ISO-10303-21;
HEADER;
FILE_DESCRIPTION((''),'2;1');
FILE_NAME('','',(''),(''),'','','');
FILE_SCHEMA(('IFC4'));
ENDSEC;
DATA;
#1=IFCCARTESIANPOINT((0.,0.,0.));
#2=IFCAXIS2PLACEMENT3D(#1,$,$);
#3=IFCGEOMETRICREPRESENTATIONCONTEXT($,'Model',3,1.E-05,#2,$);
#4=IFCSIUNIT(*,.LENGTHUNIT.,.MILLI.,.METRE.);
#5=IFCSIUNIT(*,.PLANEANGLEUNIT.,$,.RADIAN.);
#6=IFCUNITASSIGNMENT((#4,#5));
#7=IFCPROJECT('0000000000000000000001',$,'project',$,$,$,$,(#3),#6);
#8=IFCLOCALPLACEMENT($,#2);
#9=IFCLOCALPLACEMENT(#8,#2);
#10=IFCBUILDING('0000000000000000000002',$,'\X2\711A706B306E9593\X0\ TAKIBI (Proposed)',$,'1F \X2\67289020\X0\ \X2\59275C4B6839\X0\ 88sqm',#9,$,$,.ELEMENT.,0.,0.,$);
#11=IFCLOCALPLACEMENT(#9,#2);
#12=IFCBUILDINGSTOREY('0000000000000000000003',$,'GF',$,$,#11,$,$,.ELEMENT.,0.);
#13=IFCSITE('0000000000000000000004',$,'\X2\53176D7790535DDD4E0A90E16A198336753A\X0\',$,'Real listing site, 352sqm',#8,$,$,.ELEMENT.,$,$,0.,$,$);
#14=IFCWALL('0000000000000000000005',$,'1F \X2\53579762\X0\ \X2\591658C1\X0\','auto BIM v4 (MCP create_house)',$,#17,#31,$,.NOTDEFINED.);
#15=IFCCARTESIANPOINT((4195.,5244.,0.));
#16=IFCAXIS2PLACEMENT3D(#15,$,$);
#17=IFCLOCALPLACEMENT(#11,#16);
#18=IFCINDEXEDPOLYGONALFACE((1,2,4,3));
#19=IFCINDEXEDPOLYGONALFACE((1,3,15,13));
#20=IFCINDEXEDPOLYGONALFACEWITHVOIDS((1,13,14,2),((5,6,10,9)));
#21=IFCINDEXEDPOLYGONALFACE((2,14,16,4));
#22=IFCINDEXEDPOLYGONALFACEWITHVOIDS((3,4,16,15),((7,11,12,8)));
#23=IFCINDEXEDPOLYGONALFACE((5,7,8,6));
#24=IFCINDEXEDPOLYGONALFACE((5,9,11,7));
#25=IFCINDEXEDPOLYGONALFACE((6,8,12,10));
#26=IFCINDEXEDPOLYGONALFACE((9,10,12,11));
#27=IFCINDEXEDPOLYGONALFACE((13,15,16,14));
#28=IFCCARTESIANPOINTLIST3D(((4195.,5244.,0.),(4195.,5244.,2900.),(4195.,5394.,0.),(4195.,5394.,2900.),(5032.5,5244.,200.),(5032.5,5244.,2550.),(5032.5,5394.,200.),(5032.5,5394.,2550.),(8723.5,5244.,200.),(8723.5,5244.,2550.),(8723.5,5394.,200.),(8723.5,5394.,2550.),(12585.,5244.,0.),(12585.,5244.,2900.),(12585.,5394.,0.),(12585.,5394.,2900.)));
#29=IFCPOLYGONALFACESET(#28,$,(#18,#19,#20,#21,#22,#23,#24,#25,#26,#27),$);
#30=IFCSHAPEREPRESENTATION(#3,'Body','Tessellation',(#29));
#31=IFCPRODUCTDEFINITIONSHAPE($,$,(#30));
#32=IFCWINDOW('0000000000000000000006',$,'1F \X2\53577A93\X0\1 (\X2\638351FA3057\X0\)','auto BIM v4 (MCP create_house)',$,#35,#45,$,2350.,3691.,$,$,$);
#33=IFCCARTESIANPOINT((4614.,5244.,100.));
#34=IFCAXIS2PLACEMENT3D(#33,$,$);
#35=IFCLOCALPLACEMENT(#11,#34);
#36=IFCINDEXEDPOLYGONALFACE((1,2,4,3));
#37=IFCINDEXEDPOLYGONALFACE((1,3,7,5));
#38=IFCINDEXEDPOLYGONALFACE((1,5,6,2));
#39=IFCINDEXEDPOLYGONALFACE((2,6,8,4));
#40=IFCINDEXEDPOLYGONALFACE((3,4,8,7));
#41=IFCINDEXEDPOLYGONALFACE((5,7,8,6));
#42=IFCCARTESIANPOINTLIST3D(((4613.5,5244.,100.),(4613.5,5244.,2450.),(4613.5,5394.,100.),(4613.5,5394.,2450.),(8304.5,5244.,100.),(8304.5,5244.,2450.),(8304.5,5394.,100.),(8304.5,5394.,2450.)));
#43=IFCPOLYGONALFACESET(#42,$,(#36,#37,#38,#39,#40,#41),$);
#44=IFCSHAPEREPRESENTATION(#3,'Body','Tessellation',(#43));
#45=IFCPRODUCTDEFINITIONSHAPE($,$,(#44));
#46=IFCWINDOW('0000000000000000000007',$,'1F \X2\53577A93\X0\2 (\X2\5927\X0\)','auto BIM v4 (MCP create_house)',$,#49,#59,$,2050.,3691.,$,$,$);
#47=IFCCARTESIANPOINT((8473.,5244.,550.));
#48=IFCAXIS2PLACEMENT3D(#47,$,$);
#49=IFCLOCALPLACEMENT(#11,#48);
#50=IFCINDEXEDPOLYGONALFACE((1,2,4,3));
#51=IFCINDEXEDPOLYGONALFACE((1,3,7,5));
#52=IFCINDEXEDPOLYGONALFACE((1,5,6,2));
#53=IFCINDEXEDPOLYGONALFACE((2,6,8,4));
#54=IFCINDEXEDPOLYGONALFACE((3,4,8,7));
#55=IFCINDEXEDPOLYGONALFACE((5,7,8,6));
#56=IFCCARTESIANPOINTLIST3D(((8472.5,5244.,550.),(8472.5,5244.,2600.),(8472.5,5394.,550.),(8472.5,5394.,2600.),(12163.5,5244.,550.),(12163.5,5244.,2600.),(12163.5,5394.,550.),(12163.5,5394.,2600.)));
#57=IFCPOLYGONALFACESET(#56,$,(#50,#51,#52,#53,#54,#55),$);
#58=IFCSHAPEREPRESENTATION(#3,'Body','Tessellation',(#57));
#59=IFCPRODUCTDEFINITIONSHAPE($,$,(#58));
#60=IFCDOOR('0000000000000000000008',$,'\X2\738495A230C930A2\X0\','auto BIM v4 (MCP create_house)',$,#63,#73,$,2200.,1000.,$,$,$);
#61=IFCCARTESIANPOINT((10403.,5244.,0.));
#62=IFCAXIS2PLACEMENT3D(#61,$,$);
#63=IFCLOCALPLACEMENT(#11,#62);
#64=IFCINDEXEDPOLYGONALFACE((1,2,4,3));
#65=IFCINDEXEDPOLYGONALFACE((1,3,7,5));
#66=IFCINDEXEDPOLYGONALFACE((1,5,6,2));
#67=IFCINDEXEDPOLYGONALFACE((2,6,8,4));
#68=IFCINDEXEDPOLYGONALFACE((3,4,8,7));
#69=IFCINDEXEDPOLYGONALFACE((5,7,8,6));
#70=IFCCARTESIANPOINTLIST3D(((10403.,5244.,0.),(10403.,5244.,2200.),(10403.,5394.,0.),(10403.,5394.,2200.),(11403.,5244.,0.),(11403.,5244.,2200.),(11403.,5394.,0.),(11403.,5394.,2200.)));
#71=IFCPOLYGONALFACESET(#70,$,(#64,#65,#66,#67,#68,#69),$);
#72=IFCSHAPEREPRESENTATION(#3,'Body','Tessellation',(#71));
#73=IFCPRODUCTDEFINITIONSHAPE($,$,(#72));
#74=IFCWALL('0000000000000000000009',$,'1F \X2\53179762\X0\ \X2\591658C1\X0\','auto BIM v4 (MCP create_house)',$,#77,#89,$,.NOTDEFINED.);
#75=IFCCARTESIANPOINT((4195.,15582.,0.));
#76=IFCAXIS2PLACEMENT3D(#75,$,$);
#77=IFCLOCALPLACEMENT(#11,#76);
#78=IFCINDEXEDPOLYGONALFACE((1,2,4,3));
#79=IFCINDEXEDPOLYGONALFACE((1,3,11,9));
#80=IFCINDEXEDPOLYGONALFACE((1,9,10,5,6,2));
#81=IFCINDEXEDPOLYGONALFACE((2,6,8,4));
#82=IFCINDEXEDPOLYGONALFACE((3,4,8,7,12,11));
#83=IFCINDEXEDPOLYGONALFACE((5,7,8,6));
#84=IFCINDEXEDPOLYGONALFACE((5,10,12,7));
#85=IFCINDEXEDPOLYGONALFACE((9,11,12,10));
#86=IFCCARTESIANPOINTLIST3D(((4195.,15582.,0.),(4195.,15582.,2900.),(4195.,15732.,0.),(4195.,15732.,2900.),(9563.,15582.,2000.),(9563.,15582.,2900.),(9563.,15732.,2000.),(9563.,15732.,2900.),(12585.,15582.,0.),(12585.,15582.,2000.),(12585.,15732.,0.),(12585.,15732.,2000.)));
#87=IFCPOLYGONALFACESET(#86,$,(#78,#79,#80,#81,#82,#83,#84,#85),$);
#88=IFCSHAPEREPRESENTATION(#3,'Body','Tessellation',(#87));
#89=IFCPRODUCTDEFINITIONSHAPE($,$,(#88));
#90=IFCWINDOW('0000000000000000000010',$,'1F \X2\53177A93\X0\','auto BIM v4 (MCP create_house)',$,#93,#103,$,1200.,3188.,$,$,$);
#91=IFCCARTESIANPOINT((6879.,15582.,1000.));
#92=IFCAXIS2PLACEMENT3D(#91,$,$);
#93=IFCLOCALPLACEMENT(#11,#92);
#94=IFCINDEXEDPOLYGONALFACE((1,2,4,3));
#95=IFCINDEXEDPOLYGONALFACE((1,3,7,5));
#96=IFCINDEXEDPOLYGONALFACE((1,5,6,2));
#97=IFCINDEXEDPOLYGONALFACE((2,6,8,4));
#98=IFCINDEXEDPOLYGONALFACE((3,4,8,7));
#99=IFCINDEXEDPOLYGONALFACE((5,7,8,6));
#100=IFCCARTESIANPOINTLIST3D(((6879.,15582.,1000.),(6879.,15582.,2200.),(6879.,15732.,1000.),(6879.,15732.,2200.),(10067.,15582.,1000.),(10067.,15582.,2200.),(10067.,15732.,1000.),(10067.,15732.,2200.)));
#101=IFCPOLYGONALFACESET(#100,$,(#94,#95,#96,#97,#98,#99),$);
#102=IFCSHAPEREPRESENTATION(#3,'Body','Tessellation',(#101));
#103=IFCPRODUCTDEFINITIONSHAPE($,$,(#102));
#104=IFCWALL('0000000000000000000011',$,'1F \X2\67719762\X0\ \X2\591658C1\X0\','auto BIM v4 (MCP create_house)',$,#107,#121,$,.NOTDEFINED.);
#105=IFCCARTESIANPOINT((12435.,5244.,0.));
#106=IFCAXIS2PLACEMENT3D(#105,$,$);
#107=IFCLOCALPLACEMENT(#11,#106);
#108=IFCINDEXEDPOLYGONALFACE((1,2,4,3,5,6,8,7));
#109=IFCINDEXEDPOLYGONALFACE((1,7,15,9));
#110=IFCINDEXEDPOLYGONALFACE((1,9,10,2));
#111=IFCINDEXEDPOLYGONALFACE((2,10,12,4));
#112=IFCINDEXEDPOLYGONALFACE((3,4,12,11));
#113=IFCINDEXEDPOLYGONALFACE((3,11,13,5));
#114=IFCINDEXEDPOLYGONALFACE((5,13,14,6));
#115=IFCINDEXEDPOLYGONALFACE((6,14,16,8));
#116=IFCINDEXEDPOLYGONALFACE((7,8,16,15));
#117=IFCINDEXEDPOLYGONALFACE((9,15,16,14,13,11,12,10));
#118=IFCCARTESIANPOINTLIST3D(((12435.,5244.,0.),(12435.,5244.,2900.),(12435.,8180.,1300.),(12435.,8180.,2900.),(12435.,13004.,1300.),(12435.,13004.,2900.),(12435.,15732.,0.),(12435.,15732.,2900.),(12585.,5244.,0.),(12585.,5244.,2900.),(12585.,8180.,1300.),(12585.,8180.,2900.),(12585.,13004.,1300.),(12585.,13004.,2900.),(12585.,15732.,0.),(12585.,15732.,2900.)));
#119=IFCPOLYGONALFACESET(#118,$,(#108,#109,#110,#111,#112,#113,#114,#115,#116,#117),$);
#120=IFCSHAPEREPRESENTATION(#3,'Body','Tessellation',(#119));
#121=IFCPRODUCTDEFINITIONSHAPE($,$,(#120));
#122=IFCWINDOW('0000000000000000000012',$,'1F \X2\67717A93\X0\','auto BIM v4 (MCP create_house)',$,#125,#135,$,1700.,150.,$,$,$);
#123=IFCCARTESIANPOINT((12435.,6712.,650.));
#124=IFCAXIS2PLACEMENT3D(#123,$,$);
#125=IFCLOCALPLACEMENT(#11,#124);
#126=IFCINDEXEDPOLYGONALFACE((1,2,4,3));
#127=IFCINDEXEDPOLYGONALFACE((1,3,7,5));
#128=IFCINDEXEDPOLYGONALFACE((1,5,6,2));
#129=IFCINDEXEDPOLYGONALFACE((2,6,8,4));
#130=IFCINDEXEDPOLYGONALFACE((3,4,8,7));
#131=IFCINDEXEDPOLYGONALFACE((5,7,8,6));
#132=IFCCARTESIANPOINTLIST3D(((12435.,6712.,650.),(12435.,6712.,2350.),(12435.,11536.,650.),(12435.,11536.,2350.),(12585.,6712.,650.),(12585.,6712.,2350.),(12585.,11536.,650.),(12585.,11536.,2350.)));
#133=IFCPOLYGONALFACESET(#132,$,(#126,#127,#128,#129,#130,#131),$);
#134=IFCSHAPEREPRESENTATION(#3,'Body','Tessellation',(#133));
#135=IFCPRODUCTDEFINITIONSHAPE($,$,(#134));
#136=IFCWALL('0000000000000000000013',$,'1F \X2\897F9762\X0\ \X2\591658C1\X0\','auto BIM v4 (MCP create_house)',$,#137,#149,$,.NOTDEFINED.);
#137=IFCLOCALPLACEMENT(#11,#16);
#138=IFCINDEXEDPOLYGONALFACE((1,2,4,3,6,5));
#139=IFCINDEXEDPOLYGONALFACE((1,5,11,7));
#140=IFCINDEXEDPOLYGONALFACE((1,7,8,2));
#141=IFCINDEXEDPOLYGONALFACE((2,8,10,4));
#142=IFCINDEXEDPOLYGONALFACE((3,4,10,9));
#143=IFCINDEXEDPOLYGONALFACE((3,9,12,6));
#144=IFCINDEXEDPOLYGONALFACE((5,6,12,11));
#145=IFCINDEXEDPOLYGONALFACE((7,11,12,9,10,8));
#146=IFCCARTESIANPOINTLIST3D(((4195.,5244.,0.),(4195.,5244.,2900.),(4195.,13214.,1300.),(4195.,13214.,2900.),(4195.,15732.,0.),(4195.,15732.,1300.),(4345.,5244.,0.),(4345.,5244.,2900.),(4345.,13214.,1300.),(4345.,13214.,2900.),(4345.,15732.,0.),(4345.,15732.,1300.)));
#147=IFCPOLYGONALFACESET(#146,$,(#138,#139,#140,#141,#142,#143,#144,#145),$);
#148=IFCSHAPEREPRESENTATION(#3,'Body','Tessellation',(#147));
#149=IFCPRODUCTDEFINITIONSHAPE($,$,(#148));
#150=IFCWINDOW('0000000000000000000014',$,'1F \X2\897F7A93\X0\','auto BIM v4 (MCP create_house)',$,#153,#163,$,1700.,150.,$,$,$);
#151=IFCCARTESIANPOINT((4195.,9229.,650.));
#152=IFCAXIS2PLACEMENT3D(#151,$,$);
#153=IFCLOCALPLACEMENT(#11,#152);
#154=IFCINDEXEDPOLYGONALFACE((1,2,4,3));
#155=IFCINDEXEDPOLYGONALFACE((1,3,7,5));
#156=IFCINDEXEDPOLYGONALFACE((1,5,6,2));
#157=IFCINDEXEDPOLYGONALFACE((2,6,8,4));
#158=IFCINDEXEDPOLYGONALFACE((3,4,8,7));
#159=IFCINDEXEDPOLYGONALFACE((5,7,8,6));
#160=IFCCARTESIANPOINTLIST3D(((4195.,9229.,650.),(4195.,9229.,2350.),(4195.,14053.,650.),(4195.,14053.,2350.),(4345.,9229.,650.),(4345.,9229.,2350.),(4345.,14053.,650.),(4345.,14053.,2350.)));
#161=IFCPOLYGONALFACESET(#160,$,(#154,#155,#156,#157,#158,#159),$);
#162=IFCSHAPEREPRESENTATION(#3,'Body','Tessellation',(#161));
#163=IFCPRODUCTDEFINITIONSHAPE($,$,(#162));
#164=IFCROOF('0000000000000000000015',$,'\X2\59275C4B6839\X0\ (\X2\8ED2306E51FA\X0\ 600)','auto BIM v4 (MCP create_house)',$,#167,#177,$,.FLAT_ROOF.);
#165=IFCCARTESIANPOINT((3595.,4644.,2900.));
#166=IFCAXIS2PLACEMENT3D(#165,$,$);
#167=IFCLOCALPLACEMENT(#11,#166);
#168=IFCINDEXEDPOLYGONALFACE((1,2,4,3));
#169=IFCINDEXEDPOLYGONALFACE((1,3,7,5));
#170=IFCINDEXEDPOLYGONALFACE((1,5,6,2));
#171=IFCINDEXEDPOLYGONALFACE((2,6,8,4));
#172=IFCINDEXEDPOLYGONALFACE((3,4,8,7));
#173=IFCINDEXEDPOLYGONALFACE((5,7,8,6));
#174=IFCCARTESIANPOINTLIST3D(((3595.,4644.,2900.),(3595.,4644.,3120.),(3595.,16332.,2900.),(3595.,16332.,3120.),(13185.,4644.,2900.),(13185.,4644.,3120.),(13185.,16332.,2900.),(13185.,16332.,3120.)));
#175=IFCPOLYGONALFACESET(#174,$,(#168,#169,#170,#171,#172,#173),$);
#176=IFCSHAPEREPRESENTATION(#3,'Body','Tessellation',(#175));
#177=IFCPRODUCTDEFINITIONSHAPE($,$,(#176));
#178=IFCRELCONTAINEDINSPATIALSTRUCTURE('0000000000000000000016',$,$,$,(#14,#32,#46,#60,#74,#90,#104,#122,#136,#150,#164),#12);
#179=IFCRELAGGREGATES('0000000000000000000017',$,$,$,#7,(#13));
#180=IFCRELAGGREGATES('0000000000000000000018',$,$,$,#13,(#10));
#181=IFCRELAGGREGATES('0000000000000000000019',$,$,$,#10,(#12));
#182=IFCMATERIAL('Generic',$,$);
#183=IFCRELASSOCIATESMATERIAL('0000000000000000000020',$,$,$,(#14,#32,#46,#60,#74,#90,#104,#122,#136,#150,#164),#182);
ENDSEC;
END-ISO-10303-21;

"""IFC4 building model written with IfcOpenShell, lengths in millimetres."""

from ifc_helpers import new_model, si_unit, frame, frame_2d, origin, place, context, project, spatial, rectangle, extrude, material, element, fill, save


model = new_model("IFC4")

# Units and contexts
model_context = context("Model", 3, precision=1e-05, world=origin())
ifc_project = project(units=[si_unit("LENGTHUNIT", "METRE", prefix="MILLI"), si_unit("PLANEANGLEUNIT", "RADIAN")], contexts=[model_context])

# Site, building, storey
site_placement = place(None, origin())
site = spatial("IfcSite", under=ifc_project, at=site_placement, Name="北海道川上郡標茶町", ObjectType="Real listing site, 352sqm", CompositionType="ELEMENT", RefElevation=0.0)
building_placement = place(site_placement, origin())
building = spatial("IfcBuilding", under=site, at=building_placement, Name="焚火の間 TAKIBI (Proposed)", ObjectType="1F 木造 大屋根 88sqm", CompositionType="ELEMENT", ElevationOfRefHeight=0.0, ElevationOfTerrain=0.0)
storey_placement = place(building_placement, origin())
storey = spatial("IfcBuildingStorey", under=building, at=storey_placement, Name="GF", CompositionType="ELEMENT", Elevation=0.0)

# Shared definitions
ifc_material = material(Name="Generic")

# Wall, openings, windows, door
wall_1_placement = place(storey_placement, frame((4195.0, 5244.0, 0.0)))
wall_1 = element("IfcWall", 1, at=wall_1_placement, inside=storey, material=ifc_material, Name="1F 南面 外壁", Description="auto BIM v4 (MCP create_house)", PredefinedType="NOTDEFINED", context=model_context, shape_type="SweptSolid", body=[
    extrude(rectangle(XDim=8390.0, YDim=150.0, at=frame_2d((4195.0, 75.0))), frame((4195.0, 5244.0, 0.0)), (0.0, 0.0, 1.0), 2900.0),
])
opening_1_placement = place(storey_placement, frame((4614.0, 5244.0, 100.0)))
opening_1 = element("IfcOpeningElement", 2, at=opening_1_placement, cuts=wall_1, PredefinedType="NOTDEFINED", context=model_context, shape_type="SweptSolid", body=[
    extrude(rectangle(XDim=3691.0, YDim=150.0, at=frame_2d((1845.0, 75.0))), frame((4614.0, 5244.0, 100.0)), (0.0, 0.0, 1.0), 2350.0),
])
opening_2_placement = place(storey_placement, frame((8473.0, 5244.0, 550.0)))
opening_2 = element("IfcOpeningElement", 3, at=opening_2_placement, cuts=wall_1, PredefinedType="NOTDEFINED", context=model_context, shape_type="SweptSolid", body=[
    extrude(rectangle(XDim=3691.0, YDim=150.0, at=frame_2d((1845.0, 75.0))), frame((8473.0, 5244.0, 550.0)), (0.0, 0.0, 1.0), 2050.0),
])
opening_3_placement = place(storey_placement, frame((10403.0, 5244.0, 0.0)))
opening_3 = element("IfcOpeningElement", 4, at=opening_3_placement, cuts=wall_1, PredefinedType="NOTDEFINED", context=model_context, shape_type="SweptSolid", body=[
    extrude(rectangle(XDim=1000.0, YDim=150.0, at=frame_2d((500.0, 75.0))), frame((10403.0, 5244.0, 0.0)), (0.0, 0.0, 1.0), 2200.0),
])
window_1_placement = place(storey_placement, frame((4614.0, 5244.0, 100.0)))
window_1 = element("IfcWindow", 5, at=window_1_placement, inside=storey, material=ifc_material, Name="1F 南窓1 (掃出し)", Description="auto BIM v4 (MCP create_house)", OverallHeight=2350.0, OverallWidth=3691.0, context=model_context, shape_type="SweptSolid", body=[
    extrude(rectangle(XDim=3691.0, YDim=150.0, at=frame_2d((1845.0, 75.0))), frame((4614.0, 5244.0, 100.0)), (0.0, 0.0, 1.0), 2350.0),
])
fill(opening_1, window_1)
window_2_placement = place(storey_placement, frame((8473.0, 5244.0, 550.0)))
window_2 = element("IfcWindow", 6, at=window_2_placement, inside=storey, material=ifc_material, Name="1F 南窓2 (大)", Description="auto BIM v4 (MCP create_house)", OverallHeight=2050.0, OverallWidth=3691.0, context=model_context, shape_type="SweptSolid", body=[
    extrude(rectangle(XDim=3691.0, YDim=150.0, at=frame_2d((1845.0, 75.0))), frame((8473.0, 5244.0, 550.0)), (0.0, 0.0, 1.0), 2050.0),
])
fill(opening_2, window_2)
door_placement = place(storey_placement, frame((10403.0, 5244.0, 0.0)))
door = element("IfcDoor", 7, at=door_placement, inside=storey, material=ifc_material, Name="玄関ドア", Description="auto BIM v4 (MCP create_house)", OverallHeight=2200.0, OverallWidth=1000.0, context=model_context, shape_type="SweptSolid", body=[
    extrude(rectangle(XDim=1000.0, YDim=150.0, at=frame_2d((500.0, 75.0))), frame((10403.0, 5244.0, 0.0)), (0.0, 0.0, 1.0), 2200.0),
])
fill(opening_3, door)

# Walls, openings, windows
wall_2_placement = place(storey_placement, frame((4195.0, 15582.0, 0.0)))
wall_2 = element("IfcWall", 8, at=wall_2_placement, inside=storey, material=ifc_material, Name="1F 北面 外壁", Description="auto BIM v4 (MCP create_house)", PredefinedType="NOTDEFINED", context=model_context, shape_type="SweptSolid", body=[
    extrude(rectangle(XDim=8390.0, YDim=150.0, at=frame_2d((4195.0, 75.0))), frame((4195.0, 15582.0, 0.0)), (0.0, 0.0, 1.0), 2900.0),
])
opening_4_placement = place(storey_placement, frame((6879.0, 15582.0, 1000.0)))
opening_4 = element("IfcOpeningElement", 9, at=opening_4_placement, cuts=wall_2, PredefinedType="NOTDEFINED", context=model_context, shape_type="SweptSolid", body=[
    extrude(rectangle(XDim=3188.0, YDim=150.0, at=frame_2d((1594.0, 75.0))), frame((6879.0, 15582.0, 1000.0)), (0.0, 0.0, 1.0), 1200.0),
])
window_3_placement = place(storey_placement, frame((6879.0, 15582.0, 1000.0)))
window_3 = element("IfcWindow", 10, at=window_3_placement, inside=storey, material=ifc_material, Name="1F 北窓", Description="auto BIM v4 (MCP create_house)", OverallHeight=1200.0, OverallWidth=3188.0, context=model_context, shape_type="SweptSolid", body=[
    extrude(rectangle(XDim=3188.0, YDim=150.0, at=frame_2d((1594.0, 75.0))), frame((6879.0, 15582.0, 1000.0)), (0.0, 0.0, 1.0), 1200.0),
])
fill(opening_4, window_3)
wall_3_placement = place(storey_placement, frame((12435.0, 5244.0, 0.0)))
wall_3 = element("IfcWall", 11, at=wall_3_placement, inside=storey, material=ifc_material, Name="1F 東面 外壁", Description="auto BIM v4 (MCP create_house)", PredefinedType="NOTDEFINED", context=model_context, shape_type="SweptSolid", body=[
    extrude(rectangle(XDim=150.0, YDim=10488.0, at=frame_2d((75.0, 5244.0))), frame((12435.0, 5244.0, 0.0)), (0.0, 0.0, 1.0), 2900.0),
])
opening_5_placement = place(storey_placement, frame((12435.0, 6712.0, 650.0)))
opening_5 = element("IfcOpeningElement", 12, at=opening_5_placement, cuts=wall_3, PredefinedType="NOTDEFINED", context=model_context, shape_type="SweptSolid", body=[
    extrude(rectangle(XDim=150.0, YDim=4824.0, at=frame_2d((75.0, 2412.0))), frame((12435.0, 6712.0, 650.0)), (0.0, 0.0, 1.0), 1700.0),
])
window_4_placement = place(storey_placement, frame((12435.0, 6712.0, 650.0)))
window_4 = element("IfcWindow", 13, at=window_4_placement, inside=storey, material=ifc_material, Name="1F 東窓", Description="auto BIM v4 (MCP create_house)", OverallHeight=1700.0, OverallWidth=150.0, context=model_context, shape_type="SweptSolid", body=[
    extrude(rectangle(XDim=150.0, YDim=4824.0, at=frame_2d((75.0, 2412.0))), frame((12435.0, 6712.0, 650.0)), (0.0, 0.0, 1.0), 1700.0),
])
fill(opening_5, window_4)
wall_4_placement = place(storey_placement, frame((4195.0, 5244.0, 0.0)))
wall_4 = element("IfcWall", 14, at=wall_4_placement, inside=storey, material=ifc_material, Name="1F 西面 外壁", Description="auto BIM v4 (MCP create_house)", PredefinedType="NOTDEFINED", context=model_context, shape_type="SweptSolid", body=[
    extrude(rectangle(XDim=150.0, YDim=10488.0, at=frame_2d((75.0, 5244.0))), frame((4195.0, 5244.0, 0.0)), (0.0, 0.0, 1.0), 2900.0),
])
opening_6_placement = place(storey_placement, frame((4195.0, 9229.0, 650.0)))
opening_6 = element("IfcOpeningElement", 15, at=opening_6_placement, cuts=wall_4, PredefinedType="NOTDEFINED", context=model_context, shape_type="SweptSolid", body=[
    extrude(rectangle(XDim=150.0, YDim=4824.0, at=frame_2d((75.0, 2412.0))), frame((4195.0, 9229.0, 650.0)), (0.0, 0.0, 1.0), 1700.0),
])
window_5_placement = place(storey_placement, frame((4195.0, 9229.0, 650.0)))
window_5 = element("IfcWindow", 16, at=window_5_placement, inside=storey, material=ifc_material, Name="1F 西窓", Description="auto BIM v4 (MCP create_house)", OverallHeight=1700.0, OverallWidth=150.0, context=model_context, shape_type="SweptSolid", body=[
    extrude(rectangle(XDim=150.0, YDim=4824.0, at=frame_2d((75.0, 2412.0))), frame((4195.0, 9229.0, 650.0)), (0.0, 0.0, 1.0), 1700.0),
])
fill(opening_6, window_5)

# Roof
roof_placement = place(storey_placement, frame((3595.0, 4644.0, 2900.0)))
element("IfcRoof", 17, at=roof_placement, inside=storey, material=ifc_material, Name="大屋根 (軒の出 600)", Description="auto BIM v4 (MCP create_house)", PredefinedType="FLAT_ROOF", context=model_context, shape_type="SweptSolid", body=[
    extrude(rectangle(XDim=9590.0, YDim=11688.0, at=frame_2d((4795.0, 5844.0))), frame((3595.0, 4644.0, 2900.0)), (0.0, 0.0, 1.0), 220.0),
])

save(model, "model.ifc")
